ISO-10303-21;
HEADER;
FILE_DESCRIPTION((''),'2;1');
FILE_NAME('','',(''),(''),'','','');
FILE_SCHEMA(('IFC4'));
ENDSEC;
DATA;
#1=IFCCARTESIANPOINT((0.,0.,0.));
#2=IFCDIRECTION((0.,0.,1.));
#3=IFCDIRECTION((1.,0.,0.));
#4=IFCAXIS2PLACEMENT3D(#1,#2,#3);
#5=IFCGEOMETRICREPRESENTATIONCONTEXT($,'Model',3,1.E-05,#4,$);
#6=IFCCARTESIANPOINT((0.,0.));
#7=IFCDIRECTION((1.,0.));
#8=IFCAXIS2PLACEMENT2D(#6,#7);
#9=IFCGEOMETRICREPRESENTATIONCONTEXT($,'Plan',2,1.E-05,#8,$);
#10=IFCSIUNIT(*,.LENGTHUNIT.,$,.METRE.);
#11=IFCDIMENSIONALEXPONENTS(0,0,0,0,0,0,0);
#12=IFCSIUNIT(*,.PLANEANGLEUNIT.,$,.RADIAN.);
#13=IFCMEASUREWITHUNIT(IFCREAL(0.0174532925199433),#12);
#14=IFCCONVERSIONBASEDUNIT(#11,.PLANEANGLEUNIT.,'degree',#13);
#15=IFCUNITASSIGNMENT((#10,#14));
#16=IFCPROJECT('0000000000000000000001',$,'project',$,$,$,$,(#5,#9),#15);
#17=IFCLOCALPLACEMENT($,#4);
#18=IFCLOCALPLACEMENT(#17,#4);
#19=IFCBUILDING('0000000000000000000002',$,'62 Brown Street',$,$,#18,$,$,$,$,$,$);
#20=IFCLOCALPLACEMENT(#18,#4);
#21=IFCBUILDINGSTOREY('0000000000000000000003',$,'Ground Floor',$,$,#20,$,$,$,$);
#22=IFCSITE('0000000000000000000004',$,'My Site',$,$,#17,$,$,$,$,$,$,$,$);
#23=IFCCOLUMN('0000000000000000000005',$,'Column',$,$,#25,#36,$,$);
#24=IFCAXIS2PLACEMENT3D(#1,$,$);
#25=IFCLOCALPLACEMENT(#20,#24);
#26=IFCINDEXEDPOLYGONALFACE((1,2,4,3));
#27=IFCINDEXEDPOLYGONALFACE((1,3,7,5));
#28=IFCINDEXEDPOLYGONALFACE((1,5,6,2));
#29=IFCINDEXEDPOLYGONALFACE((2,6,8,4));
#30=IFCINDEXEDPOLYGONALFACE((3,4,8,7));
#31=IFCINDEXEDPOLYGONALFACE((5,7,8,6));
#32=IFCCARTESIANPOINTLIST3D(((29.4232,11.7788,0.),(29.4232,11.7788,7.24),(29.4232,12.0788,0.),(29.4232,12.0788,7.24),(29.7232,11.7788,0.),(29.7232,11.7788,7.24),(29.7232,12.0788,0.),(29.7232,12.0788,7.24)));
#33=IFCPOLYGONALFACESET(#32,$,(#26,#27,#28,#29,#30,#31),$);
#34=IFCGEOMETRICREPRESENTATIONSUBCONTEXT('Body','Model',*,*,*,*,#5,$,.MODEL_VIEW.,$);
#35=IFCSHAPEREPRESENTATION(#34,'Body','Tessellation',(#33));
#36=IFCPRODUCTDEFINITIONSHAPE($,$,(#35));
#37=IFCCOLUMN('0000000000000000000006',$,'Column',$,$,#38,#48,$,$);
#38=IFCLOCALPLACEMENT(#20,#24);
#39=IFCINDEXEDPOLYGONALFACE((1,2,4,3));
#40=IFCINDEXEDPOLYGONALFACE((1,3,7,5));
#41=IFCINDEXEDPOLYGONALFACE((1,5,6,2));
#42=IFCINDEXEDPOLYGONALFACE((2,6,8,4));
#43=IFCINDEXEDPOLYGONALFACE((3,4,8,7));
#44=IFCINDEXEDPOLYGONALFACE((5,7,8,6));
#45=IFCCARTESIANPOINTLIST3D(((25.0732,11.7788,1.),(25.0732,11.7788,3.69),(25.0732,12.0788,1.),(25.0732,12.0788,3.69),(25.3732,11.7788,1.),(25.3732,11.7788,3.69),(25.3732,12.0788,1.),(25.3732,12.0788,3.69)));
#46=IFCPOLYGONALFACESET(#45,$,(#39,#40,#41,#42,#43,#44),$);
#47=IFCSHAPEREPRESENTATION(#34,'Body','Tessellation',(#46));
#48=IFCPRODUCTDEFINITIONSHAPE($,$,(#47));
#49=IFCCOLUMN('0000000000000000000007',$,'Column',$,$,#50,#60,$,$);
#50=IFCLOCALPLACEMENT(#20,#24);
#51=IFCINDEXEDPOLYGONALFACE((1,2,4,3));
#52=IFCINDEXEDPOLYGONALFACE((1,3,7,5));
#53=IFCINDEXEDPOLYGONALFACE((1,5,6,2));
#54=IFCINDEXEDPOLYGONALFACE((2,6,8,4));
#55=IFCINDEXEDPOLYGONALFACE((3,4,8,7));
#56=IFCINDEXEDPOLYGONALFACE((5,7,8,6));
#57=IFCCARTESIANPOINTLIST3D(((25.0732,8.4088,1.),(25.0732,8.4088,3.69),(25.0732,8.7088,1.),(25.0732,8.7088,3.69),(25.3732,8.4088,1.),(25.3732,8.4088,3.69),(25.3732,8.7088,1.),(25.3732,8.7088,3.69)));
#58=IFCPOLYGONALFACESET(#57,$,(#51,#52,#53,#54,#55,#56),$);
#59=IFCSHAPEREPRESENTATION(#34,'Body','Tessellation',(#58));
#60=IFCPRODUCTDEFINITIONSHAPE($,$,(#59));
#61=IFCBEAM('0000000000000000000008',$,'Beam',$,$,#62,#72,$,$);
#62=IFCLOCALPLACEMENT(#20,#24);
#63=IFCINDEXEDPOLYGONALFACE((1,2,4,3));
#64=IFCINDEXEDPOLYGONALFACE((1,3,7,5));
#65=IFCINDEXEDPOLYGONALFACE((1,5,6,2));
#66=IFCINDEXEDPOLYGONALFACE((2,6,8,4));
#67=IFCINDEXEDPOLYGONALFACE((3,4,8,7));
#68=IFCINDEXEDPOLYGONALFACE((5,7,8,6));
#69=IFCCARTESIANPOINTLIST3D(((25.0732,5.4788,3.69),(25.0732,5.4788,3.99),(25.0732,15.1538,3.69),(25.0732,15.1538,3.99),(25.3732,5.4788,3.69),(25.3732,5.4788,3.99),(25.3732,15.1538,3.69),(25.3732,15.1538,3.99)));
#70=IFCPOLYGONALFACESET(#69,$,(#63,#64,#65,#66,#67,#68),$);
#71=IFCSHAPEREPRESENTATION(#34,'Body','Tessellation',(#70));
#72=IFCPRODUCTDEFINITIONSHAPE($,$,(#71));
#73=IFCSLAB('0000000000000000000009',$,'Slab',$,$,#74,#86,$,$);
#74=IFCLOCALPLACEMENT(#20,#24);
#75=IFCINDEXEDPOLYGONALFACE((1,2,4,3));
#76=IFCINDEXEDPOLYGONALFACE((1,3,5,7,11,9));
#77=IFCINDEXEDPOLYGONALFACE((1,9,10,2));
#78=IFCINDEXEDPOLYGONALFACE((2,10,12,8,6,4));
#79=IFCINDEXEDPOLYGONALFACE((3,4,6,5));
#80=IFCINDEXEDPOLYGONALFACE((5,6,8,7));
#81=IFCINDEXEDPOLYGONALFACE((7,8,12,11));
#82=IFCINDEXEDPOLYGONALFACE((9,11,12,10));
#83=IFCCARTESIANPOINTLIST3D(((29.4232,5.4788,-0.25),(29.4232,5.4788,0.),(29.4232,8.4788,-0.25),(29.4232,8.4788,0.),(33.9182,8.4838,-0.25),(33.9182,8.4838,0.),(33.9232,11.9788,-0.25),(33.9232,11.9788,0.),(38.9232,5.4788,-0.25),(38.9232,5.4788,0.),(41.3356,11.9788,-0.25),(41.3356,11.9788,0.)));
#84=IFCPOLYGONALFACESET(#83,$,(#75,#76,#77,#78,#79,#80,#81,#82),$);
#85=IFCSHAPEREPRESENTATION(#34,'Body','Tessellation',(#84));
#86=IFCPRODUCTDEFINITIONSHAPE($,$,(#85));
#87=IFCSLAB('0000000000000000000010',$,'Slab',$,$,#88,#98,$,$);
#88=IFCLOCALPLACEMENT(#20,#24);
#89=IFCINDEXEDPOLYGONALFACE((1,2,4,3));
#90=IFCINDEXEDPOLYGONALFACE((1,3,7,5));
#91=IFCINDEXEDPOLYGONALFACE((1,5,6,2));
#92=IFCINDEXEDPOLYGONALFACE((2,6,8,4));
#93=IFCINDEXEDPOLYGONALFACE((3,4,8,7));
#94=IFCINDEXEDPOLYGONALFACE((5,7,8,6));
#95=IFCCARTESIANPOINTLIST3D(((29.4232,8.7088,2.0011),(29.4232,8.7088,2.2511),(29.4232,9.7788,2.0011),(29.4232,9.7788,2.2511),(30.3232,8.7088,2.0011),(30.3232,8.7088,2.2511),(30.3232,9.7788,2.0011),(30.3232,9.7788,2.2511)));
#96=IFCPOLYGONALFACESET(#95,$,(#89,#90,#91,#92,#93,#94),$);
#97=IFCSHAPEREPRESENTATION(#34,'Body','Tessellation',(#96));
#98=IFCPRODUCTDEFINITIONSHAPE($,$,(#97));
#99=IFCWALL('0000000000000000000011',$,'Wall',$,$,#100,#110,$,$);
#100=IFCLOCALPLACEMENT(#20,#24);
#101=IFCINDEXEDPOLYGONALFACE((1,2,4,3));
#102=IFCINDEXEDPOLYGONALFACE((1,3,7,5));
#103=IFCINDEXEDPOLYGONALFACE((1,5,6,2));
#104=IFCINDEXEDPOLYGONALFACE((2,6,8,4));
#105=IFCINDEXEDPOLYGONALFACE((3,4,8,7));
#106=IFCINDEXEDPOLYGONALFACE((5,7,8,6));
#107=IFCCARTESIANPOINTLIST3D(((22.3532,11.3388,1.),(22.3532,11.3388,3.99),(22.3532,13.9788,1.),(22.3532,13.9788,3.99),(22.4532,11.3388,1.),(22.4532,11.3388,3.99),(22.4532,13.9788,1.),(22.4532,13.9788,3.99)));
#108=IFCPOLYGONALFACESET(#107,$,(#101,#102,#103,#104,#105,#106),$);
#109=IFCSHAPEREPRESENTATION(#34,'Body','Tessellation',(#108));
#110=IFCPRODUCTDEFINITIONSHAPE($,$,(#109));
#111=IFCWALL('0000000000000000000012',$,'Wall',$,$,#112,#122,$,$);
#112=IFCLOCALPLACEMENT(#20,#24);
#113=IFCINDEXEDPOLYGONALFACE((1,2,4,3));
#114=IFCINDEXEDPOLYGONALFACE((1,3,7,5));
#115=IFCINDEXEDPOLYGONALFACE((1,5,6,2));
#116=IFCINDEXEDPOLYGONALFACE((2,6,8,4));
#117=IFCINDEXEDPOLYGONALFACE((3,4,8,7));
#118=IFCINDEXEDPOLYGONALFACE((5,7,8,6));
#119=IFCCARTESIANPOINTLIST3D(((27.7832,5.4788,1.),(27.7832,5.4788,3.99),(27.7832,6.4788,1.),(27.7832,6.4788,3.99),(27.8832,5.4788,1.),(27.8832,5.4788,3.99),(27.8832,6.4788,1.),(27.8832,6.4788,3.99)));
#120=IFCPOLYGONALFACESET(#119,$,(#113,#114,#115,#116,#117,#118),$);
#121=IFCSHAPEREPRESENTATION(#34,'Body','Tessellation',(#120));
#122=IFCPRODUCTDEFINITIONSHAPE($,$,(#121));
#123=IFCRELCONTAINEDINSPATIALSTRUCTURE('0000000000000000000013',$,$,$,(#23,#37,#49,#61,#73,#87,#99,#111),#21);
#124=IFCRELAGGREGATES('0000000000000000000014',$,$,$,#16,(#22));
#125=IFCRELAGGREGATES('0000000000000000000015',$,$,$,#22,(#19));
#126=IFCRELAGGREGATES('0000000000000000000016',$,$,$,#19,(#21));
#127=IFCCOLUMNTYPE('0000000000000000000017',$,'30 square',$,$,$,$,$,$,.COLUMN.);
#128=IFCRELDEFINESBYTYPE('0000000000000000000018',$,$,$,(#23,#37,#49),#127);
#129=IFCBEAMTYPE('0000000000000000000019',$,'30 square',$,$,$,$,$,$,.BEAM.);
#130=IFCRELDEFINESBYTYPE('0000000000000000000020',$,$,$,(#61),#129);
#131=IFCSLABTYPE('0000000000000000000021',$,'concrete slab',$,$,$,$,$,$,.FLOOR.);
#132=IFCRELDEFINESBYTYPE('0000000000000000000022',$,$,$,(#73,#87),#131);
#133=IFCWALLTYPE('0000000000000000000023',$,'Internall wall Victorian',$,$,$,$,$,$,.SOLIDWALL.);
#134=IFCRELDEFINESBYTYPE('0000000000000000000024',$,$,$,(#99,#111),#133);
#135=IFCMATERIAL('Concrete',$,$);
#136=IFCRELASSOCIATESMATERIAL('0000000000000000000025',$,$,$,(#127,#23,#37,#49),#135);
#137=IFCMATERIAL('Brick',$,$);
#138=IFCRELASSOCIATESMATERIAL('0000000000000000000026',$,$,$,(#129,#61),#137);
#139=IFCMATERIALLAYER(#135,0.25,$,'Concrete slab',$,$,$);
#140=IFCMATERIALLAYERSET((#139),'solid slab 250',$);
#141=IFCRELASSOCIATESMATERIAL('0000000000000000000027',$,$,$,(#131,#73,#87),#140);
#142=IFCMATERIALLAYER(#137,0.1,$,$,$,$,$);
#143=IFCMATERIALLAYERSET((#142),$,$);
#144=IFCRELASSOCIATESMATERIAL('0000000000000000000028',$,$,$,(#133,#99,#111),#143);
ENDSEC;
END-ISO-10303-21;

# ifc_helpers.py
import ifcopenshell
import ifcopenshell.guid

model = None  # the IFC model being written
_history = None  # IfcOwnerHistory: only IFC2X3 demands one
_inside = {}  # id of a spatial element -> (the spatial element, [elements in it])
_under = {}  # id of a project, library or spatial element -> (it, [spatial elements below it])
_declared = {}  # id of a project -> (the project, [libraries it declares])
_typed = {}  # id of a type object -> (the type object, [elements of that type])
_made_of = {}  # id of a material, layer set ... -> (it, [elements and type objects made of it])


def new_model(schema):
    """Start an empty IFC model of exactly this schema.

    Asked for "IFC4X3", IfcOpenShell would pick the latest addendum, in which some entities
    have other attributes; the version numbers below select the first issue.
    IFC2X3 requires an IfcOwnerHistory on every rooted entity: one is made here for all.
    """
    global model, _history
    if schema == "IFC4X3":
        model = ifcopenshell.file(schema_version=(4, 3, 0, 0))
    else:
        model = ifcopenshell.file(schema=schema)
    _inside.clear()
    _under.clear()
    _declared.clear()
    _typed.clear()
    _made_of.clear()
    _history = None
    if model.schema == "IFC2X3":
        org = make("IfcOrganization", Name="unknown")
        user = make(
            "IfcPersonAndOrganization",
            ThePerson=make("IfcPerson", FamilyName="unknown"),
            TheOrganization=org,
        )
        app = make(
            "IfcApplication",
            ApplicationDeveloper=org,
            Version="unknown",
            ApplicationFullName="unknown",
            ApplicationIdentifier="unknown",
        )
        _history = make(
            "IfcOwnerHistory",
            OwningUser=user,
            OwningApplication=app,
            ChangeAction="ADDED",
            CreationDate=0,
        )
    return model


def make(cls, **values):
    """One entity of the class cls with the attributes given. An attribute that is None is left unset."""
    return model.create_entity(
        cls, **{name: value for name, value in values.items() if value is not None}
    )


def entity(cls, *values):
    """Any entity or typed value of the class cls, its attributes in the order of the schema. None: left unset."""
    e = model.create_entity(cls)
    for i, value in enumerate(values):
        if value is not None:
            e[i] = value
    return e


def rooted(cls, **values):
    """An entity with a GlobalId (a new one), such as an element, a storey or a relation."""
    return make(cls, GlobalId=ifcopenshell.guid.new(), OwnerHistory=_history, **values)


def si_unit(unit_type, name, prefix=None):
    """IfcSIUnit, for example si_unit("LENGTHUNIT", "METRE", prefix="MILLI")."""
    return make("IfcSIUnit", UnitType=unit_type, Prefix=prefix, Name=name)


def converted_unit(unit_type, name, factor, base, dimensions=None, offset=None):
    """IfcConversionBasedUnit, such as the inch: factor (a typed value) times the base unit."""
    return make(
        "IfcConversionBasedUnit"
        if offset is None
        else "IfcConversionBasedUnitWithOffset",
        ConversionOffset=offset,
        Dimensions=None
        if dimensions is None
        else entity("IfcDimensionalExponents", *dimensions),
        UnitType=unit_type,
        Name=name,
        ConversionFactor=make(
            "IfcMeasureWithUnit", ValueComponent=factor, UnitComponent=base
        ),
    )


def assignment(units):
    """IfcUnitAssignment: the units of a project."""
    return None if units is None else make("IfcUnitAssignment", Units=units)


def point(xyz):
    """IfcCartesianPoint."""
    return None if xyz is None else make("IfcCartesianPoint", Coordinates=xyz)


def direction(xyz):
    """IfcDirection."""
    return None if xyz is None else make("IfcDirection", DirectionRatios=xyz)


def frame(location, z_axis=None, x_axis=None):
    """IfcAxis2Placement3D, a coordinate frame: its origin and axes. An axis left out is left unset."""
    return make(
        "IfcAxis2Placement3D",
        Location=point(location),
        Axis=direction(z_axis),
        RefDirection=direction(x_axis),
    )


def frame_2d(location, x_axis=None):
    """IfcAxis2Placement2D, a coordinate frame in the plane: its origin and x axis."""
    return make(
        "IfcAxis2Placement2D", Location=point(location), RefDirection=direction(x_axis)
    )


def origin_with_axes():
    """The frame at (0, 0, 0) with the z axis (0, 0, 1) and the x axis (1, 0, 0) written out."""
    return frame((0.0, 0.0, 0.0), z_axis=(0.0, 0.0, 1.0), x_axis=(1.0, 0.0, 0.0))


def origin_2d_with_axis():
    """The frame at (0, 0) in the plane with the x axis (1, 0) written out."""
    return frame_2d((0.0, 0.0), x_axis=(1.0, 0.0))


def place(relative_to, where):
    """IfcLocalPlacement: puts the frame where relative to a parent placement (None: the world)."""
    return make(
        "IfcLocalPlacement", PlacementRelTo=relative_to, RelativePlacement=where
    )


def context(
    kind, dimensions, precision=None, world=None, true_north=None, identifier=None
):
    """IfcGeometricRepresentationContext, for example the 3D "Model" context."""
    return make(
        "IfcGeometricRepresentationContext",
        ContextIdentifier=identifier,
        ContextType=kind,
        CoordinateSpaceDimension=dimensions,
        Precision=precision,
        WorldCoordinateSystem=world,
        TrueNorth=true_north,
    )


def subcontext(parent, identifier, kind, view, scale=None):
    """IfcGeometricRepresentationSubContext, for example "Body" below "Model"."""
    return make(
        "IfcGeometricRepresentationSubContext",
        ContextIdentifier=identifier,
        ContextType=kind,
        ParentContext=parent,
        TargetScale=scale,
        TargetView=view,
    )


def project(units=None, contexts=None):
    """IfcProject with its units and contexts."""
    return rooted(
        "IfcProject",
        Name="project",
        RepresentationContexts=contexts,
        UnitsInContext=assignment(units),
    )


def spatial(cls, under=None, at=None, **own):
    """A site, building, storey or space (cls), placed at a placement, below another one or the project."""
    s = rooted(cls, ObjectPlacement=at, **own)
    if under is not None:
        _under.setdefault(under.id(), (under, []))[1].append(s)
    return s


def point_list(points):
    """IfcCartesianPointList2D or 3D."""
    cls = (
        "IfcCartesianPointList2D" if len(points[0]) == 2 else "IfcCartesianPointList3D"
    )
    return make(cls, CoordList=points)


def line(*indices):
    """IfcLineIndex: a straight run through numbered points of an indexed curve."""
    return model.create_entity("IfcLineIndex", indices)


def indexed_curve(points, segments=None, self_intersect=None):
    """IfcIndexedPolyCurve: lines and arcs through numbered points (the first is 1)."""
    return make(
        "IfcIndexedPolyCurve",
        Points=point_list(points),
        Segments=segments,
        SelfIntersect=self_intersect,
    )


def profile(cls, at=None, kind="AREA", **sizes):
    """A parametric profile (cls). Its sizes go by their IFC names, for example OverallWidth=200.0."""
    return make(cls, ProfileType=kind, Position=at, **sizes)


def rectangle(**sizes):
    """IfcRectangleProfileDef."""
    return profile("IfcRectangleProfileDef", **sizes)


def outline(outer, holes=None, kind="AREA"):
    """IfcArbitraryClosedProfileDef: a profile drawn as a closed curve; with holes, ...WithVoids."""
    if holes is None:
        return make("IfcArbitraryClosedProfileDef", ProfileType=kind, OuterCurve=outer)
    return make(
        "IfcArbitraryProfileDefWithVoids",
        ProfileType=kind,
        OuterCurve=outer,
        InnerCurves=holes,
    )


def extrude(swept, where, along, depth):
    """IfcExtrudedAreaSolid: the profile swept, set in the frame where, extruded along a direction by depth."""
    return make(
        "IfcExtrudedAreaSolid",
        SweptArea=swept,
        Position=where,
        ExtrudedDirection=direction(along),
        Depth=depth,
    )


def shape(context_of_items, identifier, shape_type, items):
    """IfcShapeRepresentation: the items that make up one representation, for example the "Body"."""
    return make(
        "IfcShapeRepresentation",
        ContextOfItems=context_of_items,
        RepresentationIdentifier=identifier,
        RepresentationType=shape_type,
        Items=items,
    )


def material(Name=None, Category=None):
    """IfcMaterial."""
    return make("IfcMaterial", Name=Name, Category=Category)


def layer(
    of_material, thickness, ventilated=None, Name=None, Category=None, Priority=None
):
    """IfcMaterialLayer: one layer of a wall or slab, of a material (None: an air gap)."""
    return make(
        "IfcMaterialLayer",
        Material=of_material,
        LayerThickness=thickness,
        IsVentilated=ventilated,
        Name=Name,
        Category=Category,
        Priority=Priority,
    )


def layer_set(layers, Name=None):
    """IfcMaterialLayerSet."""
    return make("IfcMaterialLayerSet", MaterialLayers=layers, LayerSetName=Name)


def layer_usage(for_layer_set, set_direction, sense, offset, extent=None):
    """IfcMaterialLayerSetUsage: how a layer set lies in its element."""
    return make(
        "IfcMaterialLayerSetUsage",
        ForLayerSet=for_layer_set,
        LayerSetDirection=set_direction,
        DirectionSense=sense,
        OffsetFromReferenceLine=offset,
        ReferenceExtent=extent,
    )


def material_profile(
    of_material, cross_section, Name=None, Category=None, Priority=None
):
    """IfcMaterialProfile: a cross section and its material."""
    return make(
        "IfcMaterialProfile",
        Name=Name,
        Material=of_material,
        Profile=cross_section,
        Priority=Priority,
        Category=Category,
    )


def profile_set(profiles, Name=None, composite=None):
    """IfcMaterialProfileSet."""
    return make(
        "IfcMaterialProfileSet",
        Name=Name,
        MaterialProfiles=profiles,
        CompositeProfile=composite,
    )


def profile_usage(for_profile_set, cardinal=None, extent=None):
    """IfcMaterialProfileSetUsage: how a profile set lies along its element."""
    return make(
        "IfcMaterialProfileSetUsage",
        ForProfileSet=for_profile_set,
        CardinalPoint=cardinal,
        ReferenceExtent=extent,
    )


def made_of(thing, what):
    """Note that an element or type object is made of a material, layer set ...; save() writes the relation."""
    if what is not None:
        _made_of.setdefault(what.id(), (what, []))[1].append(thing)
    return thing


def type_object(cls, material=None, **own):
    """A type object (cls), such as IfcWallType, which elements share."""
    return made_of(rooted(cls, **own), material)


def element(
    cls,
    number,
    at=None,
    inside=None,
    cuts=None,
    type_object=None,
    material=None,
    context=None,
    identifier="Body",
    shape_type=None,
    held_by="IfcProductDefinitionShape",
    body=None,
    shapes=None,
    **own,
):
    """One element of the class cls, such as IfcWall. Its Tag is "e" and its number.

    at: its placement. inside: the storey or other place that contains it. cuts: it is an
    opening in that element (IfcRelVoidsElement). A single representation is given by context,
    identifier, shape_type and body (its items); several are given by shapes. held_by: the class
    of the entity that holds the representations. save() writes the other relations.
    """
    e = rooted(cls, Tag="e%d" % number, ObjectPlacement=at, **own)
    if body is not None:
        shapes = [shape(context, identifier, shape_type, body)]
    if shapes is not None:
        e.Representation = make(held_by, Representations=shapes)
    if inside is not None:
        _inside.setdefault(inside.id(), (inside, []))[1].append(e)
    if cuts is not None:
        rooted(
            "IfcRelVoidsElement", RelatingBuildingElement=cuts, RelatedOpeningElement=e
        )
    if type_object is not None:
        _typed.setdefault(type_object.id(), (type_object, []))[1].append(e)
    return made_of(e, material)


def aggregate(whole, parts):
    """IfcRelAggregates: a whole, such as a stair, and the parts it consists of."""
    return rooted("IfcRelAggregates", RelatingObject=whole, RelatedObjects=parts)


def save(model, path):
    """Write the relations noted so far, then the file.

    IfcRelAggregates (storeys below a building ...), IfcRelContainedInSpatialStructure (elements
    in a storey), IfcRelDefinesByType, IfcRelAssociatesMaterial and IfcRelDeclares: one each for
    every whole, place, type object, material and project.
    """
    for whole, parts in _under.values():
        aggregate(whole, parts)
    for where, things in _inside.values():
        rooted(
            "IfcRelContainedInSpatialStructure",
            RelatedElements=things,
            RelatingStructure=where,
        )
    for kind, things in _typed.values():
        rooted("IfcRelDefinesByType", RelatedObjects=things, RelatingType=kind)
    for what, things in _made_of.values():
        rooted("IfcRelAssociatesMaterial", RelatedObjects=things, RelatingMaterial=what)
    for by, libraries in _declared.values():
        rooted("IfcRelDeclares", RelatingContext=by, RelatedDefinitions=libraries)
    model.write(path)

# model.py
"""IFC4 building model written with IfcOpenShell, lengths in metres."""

from ifc_helpers import new_model, entity, si_unit, converted_unit, frame, origin_with_axes, origin_2d_with_axis, place, context, subcontext, project, spatial, line, indexed_curve, rectangle, outline, extrude, material, layer, layer_set, layer_usage, material_profile, profile_set, profile_usage, type_object, element, save


model = new_model("IFC4")

# Units and contexts
model_context = context("Model", 3, precision=1e-05, world=origin_with_axes())
plan_context = context("Plan", 2, precision=1e-05, world=origin_2d_with_axis())
body_context = subcontext(model_context, "Body", "Model", "MODEL_VIEW")
ifc_project = project(units=[si_unit("LENGTHUNIT", "METRE"), converted_unit("PLANEANGLEUNIT", "degree", entity("IfcReal", 0.0174532925199433), si_unit("PLANEANGLEUNIT", "RADIAN"), dimensions=[0, 0, 0, 0, 0, 0, 0])], contexts=[model_context, plan_context])

# Site, building, storey
site_placement = place(None, origin_with_axes())
site = spatial("IfcSite", under=ifc_project, at=site_placement, Name="My Site")
building_placement = place(site_placement, origin_with_axes())
building = spatial("IfcBuilding", under=site, at=building_placement, Name="62 Brown Street")
storey_placement = place(building_placement, origin_with_axes())
storey = spatial("IfcBuildingStorey", under=building, at=storey_placement, Name="Ground Floor")

# Columns
ifc_material_1 = material(Name="Concrete")
ifc_material_profile_1 = material_profile(ifc_material_1, rectangle(XDim=0.3, YDim=0.3))
ifc_profile_set_1 = profile_set([ifc_material_profile_1])
ifc_profile_usage_1 = profile_usage(ifc_profile_set_1, cardinal=5)
column_type = type_object("IfcColumnType", Name="30 square", PredefinedType="COLUMN", material=ifc_profile_set_1)
column_1_placement = place(storey_placement, frame((29.5732, 11.9288, 0.0), z_axis=(0.0, 0.0, 1.0), x_axis=(1.0, 0.0, 0.0)))
element("IfcColumn", 1, at=column_1_placement, inside=storey, type_object=column_type, material=ifc_profile_usage_1, Name="Column", context=body_context, shape_type="SweptSolid", body=[
    extrude(rectangle(XDim=0.3, YDim=0.3), origin_with_axes(), (0.0, 0.0, 1.0), 7.24),
])
ifc_profile_usage_2 = profile_usage(ifc_profile_set_1, cardinal=5)
column_2_placement = place(storey_placement, frame((25.2232, 11.9288, 1.0), z_axis=(0.0, 0.0, 1.0), x_axis=(1.0, 0.0, 0.0)))
element("IfcColumn", 2, at=column_2_placement, inside=storey, type_object=column_type, material=ifc_profile_usage_2, Name="Column", context=body_context, shape_type="SweptSolid", body=[
    extrude(rectangle(XDim=0.3, YDim=0.3), origin_with_axes(), (0.0, 0.0, 1.0), 2.69),
])
ifc_profile_usage_3 = profile_usage(ifc_profile_set_1, cardinal=5)
column_3_placement = place(storey_placement, frame((25.2232, 8.5588, 1.0), z_axis=(0.0, 0.0, 1.0), x_axis=(1.0, 0.0, 0.0)))
element("IfcColumn", 3, at=column_3_placement, inside=storey, type_object=column_type, material=ifc_profile_usage_3, Name="Column", context=body_context, shape_type="SweptSolid", body=[
    extrude(rectangle(XDim=0.3, YDim=0.3), origin_with_axes(), (0.0, 0.0, 1.0), 2.69),
])

# Beam
ifc_material_2 = material(Name="Brick")
ifc_material_profile_2 = material_profile(ifc_material_2, rectangle(XDim=0.3, YDim=0.3))
ifc_profile_set_2 = profile_set([ifc_material_profile_2])
ifc_profile_usage_4 = profile_usage(ifc_profile_set_2, cardinal=5)
beam_type = type_object("IfcBeamType", Name="30 square", PredefinedType="BEAM", material=ifc_profile_set_2)
beam_placement = place(storey_placement, frame((25.2232, 5.4788, 3.84), z_axis=(0.0, 1.0, 0.0), x_axis=(-1.0, 0.0, 0.0)))
element("IfcBeam", 4, at=beam_placement, inside=storey, type_object=beam_type, material=ifc_profile_usage_4, Name="Beam", context=body_context, shape_type="SweptSolid", body=[
    extrude(rectangle(XDim=0.3, YDim=0.3), origin_with_axes(), (0.0, 0.0, 1.0), 9.675),
])

# Slabs
ifc_layer_1 = layer(ifc_material_1, 0.25, Name="Concrete slab")
ifc_layer_set_1 = layer_set([ifc_layer_1], Name="solid slab 250")
ifc_layer_usage_1 = layer_usage(ifc_layer_set_1, "AXIS3", "POSITIVE", 0.0)
slab_type = type_object("IfcSlabType", Name="concrete slab", PredefinedType="FLOOR", material=ifc_layer_set_1)
slab_1_placement = place(storey_placement, frame((29.4232, 5.4788, -0.25), z_axis=(0.0, 0.0, 1.0), x_axis=(1.0, 0.0, 0.0)))
element("IfcSlab", 5, at=slab_1_placement, inside=storey, type_object=slab_type, material=ifc_layer_usage_1, Name="Slab", context=body_context, shape_type="SweptSolid", body=[
    extrude(outline(indexed_curve([(0.0, 0.0), (9.5, 0.0), (11.9124, 6.5), (0.0, 3.0), (4.5, 6.5), (4.495, 3.005)], segments=[line(1, 2), line(2, 3), line(3, 5), line(5, 6), line(6, 4), line(4, 1)], self_intersect=False)), None, (0.0, 0.0, 1.0), 0.25),
])
ifc_layer_usage_2 = layer_usage(ifc_layer_set_1, "AXIS3", "POSITIVE", 0.0)
slab_2_placement = place(storey_placement, frame((29.4232, 8.7088, 2.0011), z_axis=(0.0, 0.0, 1.0), x_axis=(1.0, 0.0, 0.0)))
element("IfcSlab", 6, at=slab_2_placement, inside=storey, type_object=slab_type, material=ifc_layer_usage_2, Name="Slab", context=body_context, shape_type="SweptSolid", body=[
    extrude(outline(indexed_curve([(0.9, 1.07), (0.9, 0.0), (0.0, 0.0), (0.0, 1.07)], segments=[line(3, 2), line(2, 1), line(1, 4), line(4, 3)], self_intersect=False)), None, (0.0, 0.0, 1.0), 0.25),
])

# Walls
ifc_layer_2 = layer(ifc_material_2, 0.1)
ifc_layer_set_2 = layer_set([ifc_layer_2])
ifc_layer_usage_3 = layer_usage(ifc_layer_set_2, "AXIS2", "POSITIVE", 0.0)
wall_type_1 = type_object("IfcWallType", Name="Internall wall Victorian", PredefinedType="SOLIDWALL", material=ifc_layer_set_2)
wall_1_placement = place(storey_placement, frame((22.4532, 11.3388, 1.0), z_axis=(0.0, 0.0, 1.0), x_axis=(0.0, 1.0, 0.0)))
element("IfcWall", 7, at=wall_1_placement, inside=storey, type_object=wall_type_1, material=ifc_layer_usage_3, Name="Wall", context=body_context, shape_type="SweptSolid", body=[
    extrude(outline(indexed_curve([(0.0, 0.0), (0.0, 0.1), (2.64, 0.1), (2.64, 0.0), (0.0, 0.0)], self_intersect=False)), origin_with_axes(), (0.0, 0.0, 1.0), 2.99),
])
ifc_layer_usage_4 = layer_usage(ifc_layer_set_2, "AXIS2", "POSITIVE", 0.0)
wall_2_placement = place(storey_placement, frame((27.8832, 5.4788, 1.0), z_axis=(0.0, 0.0, 1.0), x_axis=(0.0, 1.0, 0.0)))
element("IfcWall", 8, at=wall_2_placement, inside=storey, type_object=wall_type_1, material=ifc_layer_usage_4, Name="Wall", context=body_context, shape_type="SweptSolid", body=[
    extrude(outline(indexed_curve([(0.0, 0.0), (0.0, 0.1), (1.0, 0.1), (1.0, 0.0), (0.0, 0.0)], self_intersect=False)), origin_with_axes(), (0.0, 0.0, 1.0), 2.99),
])

save(model, "model.ifc")
